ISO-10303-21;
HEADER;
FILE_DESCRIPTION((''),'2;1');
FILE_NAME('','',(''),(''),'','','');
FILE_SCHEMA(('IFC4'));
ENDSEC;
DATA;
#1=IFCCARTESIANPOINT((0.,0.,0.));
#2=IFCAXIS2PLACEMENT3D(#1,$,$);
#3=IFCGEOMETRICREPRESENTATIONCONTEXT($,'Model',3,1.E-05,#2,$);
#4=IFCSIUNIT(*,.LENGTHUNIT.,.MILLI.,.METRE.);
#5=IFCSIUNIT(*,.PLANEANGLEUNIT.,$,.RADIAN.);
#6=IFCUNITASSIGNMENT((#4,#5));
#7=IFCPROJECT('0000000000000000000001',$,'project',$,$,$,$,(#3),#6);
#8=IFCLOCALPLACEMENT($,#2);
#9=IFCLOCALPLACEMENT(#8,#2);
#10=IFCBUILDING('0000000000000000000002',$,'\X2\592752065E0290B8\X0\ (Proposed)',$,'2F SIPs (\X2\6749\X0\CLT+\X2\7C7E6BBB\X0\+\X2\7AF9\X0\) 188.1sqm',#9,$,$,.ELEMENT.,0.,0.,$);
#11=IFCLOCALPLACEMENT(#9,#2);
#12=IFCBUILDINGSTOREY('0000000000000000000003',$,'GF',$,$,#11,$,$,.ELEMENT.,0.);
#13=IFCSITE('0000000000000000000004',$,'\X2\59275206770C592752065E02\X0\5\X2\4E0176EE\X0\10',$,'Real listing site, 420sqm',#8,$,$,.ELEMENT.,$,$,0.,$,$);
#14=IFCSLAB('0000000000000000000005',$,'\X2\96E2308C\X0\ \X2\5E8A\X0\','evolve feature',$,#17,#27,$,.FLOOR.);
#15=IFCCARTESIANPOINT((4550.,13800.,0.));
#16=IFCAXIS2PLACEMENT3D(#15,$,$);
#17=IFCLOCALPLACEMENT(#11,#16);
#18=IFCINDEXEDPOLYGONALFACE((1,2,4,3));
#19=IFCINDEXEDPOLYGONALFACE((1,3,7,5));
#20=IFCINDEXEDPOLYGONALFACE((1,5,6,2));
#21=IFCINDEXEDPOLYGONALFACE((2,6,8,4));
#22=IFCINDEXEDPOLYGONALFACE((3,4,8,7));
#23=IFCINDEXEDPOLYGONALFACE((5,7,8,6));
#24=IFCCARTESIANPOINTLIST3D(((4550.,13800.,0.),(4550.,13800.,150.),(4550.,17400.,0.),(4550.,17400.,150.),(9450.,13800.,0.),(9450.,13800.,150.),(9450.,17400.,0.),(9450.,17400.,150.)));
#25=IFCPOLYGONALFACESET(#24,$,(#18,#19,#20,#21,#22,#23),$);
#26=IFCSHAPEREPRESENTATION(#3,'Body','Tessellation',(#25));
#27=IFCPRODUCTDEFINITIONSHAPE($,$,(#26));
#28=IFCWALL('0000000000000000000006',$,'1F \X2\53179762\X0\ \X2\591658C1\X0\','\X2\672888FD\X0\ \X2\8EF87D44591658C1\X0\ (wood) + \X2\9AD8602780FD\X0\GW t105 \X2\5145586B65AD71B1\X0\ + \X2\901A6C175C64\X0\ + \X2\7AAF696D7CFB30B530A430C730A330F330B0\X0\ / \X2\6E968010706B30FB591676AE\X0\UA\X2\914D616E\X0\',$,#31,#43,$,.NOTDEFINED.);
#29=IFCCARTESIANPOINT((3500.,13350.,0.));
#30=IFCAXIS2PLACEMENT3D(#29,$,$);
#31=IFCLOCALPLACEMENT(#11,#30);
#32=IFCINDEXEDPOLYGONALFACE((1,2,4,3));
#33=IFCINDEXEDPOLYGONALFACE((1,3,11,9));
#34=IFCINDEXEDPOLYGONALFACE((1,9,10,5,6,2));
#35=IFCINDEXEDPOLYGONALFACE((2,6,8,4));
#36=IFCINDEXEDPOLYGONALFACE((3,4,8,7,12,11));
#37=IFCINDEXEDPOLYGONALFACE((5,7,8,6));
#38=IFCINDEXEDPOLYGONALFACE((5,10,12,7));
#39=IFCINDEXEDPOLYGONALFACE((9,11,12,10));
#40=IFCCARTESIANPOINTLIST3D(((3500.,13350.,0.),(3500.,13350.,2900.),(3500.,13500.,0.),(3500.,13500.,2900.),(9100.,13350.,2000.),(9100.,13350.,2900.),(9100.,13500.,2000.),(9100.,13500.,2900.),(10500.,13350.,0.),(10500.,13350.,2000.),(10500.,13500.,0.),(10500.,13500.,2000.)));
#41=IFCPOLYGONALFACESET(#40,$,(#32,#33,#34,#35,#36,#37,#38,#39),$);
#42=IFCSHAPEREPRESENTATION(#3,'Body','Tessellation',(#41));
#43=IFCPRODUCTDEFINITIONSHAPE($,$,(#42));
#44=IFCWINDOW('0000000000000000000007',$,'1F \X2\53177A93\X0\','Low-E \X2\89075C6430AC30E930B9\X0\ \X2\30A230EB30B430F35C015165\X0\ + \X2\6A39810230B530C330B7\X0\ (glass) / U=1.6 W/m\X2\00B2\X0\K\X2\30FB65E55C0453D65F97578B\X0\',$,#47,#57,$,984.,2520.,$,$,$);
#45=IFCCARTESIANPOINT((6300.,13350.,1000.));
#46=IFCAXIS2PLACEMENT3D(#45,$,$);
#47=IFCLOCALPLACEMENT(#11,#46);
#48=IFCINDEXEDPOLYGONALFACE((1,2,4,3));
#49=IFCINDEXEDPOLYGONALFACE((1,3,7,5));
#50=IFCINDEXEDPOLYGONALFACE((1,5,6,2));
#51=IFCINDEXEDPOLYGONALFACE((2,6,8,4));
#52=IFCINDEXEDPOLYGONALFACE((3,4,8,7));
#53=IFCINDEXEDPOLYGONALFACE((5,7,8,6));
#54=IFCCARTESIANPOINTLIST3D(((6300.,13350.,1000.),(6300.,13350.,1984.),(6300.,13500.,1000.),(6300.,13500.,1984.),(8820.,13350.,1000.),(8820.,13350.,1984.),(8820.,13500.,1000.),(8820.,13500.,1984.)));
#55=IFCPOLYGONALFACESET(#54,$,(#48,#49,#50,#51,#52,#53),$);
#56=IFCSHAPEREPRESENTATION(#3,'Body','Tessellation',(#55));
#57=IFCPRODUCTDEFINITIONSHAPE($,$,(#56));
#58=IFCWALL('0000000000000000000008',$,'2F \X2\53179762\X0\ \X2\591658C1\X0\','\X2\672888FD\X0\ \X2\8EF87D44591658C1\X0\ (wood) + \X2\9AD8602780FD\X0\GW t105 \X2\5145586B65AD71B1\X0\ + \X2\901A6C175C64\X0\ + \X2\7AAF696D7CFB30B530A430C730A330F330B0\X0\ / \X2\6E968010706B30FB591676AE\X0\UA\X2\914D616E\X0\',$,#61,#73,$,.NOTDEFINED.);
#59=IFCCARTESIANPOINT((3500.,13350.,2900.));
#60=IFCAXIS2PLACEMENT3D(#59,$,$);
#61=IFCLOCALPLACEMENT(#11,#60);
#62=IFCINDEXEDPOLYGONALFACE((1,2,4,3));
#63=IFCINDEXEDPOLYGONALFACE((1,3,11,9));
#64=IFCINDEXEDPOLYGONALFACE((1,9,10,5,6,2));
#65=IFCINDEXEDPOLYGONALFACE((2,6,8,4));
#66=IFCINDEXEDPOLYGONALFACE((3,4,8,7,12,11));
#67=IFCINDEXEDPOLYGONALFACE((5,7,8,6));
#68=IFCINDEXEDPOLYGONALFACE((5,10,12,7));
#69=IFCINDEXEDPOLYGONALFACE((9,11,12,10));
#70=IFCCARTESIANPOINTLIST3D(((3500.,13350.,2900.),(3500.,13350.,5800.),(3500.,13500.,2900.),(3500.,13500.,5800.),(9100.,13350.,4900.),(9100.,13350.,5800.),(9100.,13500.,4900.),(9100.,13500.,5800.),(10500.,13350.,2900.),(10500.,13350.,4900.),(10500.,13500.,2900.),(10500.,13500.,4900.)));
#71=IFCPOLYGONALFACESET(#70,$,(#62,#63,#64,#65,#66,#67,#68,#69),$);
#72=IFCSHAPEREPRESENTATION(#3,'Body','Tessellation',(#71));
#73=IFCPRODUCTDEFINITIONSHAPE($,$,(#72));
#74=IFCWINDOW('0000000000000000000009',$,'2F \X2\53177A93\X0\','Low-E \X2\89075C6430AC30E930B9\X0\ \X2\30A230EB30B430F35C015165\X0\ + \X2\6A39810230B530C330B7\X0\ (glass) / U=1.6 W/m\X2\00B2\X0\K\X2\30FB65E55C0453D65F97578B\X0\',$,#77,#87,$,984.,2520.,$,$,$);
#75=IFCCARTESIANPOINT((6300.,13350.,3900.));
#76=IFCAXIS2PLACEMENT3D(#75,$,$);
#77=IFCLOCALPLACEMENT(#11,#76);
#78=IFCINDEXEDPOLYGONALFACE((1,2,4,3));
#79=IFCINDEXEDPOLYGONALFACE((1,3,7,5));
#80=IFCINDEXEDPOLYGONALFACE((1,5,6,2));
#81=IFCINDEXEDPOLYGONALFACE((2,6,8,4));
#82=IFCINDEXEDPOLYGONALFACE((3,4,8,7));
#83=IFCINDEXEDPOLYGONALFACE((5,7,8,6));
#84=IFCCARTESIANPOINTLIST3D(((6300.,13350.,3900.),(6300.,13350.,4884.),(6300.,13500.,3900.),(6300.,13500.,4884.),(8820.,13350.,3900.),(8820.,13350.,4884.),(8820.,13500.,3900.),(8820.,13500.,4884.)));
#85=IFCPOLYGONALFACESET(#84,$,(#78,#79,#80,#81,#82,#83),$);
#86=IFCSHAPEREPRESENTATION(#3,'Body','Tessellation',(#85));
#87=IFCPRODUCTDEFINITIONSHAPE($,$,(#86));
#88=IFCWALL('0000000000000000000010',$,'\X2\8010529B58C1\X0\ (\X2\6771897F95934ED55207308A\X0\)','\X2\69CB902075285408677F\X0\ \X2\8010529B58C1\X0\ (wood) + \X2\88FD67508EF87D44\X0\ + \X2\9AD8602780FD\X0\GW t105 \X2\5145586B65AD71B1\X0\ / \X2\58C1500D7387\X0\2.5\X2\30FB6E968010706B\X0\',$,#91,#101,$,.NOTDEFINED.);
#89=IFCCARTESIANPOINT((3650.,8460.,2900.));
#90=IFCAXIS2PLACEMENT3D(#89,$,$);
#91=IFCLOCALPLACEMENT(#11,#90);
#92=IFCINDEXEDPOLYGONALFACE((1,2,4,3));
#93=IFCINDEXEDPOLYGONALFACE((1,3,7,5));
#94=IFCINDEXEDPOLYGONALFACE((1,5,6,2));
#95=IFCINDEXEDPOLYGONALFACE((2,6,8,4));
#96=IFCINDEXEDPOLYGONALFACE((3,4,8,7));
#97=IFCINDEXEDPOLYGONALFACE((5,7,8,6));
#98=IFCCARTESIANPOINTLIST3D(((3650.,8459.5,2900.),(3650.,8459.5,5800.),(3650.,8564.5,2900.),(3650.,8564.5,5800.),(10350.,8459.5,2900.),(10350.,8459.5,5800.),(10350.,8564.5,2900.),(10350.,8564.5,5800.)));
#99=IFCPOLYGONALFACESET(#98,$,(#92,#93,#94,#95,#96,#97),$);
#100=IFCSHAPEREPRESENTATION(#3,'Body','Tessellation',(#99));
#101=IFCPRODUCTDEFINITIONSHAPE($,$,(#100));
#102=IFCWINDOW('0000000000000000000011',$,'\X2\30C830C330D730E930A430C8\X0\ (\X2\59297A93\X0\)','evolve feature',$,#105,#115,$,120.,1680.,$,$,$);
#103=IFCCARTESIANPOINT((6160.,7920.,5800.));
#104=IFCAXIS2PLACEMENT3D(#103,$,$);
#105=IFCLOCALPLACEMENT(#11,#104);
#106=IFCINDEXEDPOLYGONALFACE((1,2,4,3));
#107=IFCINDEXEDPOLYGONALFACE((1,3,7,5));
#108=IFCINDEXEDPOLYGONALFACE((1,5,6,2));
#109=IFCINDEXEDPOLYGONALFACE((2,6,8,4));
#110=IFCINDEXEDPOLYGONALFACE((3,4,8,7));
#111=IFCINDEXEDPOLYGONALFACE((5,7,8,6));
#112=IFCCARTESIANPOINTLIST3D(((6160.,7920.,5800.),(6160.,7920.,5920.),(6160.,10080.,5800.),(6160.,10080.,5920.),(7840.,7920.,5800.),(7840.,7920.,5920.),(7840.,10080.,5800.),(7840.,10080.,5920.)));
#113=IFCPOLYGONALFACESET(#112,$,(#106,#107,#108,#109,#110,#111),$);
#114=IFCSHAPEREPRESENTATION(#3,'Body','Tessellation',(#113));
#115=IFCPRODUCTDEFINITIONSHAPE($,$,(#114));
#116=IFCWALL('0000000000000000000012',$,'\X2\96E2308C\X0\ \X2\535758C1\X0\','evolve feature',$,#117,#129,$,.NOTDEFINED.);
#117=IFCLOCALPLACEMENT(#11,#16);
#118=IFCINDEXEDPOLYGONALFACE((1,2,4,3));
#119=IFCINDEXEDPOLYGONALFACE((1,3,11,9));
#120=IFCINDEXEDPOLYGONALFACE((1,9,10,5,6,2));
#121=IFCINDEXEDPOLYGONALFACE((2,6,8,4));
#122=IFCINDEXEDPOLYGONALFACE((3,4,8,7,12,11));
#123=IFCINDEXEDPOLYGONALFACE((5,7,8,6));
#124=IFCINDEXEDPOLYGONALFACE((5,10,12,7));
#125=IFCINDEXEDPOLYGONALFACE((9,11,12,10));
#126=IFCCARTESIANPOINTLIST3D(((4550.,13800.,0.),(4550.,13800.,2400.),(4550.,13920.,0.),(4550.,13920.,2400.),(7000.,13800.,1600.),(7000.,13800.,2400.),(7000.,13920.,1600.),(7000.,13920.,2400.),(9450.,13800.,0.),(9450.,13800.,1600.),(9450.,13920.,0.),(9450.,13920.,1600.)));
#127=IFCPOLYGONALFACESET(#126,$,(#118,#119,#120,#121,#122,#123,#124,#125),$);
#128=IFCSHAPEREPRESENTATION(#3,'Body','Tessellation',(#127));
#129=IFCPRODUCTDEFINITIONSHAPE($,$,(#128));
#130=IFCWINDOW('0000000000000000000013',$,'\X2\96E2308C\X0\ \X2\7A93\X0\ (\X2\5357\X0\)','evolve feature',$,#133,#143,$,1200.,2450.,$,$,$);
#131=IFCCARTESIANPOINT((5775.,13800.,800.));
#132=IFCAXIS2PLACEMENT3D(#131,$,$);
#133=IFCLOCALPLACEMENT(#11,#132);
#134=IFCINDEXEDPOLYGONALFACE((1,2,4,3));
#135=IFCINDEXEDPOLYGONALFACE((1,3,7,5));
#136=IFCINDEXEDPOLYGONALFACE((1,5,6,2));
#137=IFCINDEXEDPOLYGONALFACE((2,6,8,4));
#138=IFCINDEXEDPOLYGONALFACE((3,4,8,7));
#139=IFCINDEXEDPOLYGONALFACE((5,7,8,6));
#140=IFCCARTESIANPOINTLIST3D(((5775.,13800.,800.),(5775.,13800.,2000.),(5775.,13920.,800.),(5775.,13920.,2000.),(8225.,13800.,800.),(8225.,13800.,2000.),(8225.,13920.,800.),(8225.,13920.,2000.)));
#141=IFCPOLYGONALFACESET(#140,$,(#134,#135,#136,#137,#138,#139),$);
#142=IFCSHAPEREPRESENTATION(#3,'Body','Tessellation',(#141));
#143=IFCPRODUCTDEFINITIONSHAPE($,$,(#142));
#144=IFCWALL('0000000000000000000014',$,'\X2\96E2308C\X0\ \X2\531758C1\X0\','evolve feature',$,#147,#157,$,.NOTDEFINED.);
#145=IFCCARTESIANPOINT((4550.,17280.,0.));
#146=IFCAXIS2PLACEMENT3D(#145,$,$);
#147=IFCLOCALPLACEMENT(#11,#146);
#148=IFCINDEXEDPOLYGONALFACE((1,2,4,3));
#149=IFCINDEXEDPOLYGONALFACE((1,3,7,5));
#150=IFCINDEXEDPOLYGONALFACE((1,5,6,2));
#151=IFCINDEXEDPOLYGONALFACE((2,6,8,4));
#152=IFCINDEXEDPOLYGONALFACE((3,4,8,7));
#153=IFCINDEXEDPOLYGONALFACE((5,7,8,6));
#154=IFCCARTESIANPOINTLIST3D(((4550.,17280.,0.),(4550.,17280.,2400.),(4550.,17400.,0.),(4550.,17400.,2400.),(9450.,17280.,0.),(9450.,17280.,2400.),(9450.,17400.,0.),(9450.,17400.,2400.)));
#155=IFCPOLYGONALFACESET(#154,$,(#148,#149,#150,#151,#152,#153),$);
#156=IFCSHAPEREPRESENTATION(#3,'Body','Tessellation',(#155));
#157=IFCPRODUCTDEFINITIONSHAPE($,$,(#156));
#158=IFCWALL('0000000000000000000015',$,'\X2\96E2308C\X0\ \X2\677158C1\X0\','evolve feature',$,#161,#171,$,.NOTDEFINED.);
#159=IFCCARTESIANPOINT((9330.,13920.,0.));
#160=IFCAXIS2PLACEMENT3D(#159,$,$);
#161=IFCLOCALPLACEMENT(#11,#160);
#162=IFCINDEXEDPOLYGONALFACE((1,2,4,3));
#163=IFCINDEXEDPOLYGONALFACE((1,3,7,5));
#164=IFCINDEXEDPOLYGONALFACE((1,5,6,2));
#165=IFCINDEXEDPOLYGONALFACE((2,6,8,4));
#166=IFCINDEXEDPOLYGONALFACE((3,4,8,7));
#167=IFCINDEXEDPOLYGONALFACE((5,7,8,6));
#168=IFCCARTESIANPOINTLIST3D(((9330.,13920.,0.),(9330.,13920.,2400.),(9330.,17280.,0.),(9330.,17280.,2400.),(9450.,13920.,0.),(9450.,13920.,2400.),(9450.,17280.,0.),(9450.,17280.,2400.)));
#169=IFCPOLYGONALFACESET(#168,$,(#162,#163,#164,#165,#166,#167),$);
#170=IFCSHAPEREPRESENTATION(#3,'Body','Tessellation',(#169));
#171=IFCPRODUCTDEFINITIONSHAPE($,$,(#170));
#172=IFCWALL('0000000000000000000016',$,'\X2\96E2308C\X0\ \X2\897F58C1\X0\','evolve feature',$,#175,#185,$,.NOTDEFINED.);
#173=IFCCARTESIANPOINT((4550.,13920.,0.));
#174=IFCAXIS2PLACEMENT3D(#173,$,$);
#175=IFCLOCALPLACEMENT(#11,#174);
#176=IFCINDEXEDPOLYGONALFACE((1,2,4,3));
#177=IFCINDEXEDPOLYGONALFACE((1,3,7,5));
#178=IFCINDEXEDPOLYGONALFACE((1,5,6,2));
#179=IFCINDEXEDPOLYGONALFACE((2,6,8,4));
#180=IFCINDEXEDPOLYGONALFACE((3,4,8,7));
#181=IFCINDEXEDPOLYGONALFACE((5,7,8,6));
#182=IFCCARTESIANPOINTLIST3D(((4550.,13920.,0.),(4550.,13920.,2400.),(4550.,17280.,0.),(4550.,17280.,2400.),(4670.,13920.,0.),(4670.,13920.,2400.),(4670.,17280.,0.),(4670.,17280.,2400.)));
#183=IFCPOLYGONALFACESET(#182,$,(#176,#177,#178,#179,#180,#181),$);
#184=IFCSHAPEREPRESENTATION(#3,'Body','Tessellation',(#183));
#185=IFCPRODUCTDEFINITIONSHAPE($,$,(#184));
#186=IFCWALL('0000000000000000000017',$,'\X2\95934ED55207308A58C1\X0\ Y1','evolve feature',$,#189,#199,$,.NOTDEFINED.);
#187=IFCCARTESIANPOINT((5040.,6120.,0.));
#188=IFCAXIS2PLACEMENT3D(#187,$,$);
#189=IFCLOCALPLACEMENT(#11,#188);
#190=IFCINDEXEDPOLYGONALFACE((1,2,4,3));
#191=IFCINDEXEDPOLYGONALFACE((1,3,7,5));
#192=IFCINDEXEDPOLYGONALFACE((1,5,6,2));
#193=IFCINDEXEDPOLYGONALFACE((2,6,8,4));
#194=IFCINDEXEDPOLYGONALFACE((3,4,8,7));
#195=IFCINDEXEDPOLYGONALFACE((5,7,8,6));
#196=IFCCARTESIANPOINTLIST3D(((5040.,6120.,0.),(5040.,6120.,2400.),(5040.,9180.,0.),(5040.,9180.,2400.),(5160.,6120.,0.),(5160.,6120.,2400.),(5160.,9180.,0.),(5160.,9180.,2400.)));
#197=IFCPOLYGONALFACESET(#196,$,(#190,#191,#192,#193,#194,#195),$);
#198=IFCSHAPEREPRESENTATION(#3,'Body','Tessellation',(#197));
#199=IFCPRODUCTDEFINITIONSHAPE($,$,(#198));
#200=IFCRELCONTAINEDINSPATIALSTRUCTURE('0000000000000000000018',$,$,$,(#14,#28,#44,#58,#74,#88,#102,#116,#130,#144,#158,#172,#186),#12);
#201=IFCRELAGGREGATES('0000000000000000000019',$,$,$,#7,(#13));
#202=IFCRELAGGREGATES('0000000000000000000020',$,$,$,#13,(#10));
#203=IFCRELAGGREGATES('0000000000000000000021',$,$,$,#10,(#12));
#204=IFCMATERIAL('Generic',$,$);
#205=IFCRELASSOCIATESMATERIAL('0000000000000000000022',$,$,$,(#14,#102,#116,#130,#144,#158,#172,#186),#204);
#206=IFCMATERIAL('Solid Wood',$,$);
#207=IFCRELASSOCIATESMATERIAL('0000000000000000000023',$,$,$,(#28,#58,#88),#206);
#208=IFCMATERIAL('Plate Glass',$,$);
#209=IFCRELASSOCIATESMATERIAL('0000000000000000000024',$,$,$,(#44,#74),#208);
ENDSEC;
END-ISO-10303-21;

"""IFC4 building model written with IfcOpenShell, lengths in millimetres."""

from ifc_helpers import new_model, si_unit, frame, frame_2d, origin, place, context, project, spatial, rectangle, extrude, material, element, fill, save


model = new_model("IFC4")

# Units and contexts
model_context = context("Model", 3, precision=1e-05, world=origin())
ifc_project = project(units=[si_unit("LENGTHUNIT", "METRE", prefix="MILLI"), si_unit("PLANEANGLEUNIT", "RADIAN")], contexts=[model_context])

# Site, building, storey
site_placement = place(None, origin())
site = spatial("IfcSite", under=ifc_project, at=site_placement, Name="大分県大分市5丁目10", ObjectType="Real listing site, 420sqm", CompositionType="ELEMENT", RefElevation=0.0)
building_placement = place(site_placement, origin())
building = spatial("IfcBuilding", under=site, at=building_placement, Name="大分市邸 (Proposed)", ObjectType="2F SIPs (杉CLT+籾殻+竹) 188.1sqm", CompositionType="ELEMENT", ElevationOfRefHeight=0.0, ElevationOfTerrain=0.0)
storey_placement = place(building_placement, origin())
storey = spatial("IfcBuildingStorey", under=building, at=storey_placement, Name="GF", CompositionType="ELEMENT", Elevation=0.0)

# Slab
ifc_material_1 = material(Name="Generic")
slab_placement = place(storey_placement, frame((4550.0, 13800.0, 0.0)))
element("IfcSlab", 1, at=slab_placement, inside=storey, material=ifc_material_1, Name="離れ 床", Description="evolve feature", PredefinedType="FLOOR", context=model_context, shape_type="SweptSolid", body=[
    extrude(rectangle(XDim=4900.0, YDim=3600.0, at=frame_2d((2450.0, 1800.0))), frame((4550.0, 13800.0, 0.0)), (0.0, 0.0, 1.0), 150.0),
])

# Wall, opening, window
ifc_material_2 = material(Name="Solid Wood")
wall_1_placement = place(storey_placement, frame((3500.0, 13350.0, 0.0)))
wall_1 = element("IfcWall", 2, at=wall_1_placement, inside=storey, material=ifc_material_2, Name="1F 北面 外壁", Description="木製 軸組外壁 (wood) + 高性能GW t105 充填断熱 + 通気層 + 窯業系サイディング / 準耐火・外皮UA配慮", PredefinedType="NOTDEFINED", context=model_context, shape_type="SweptSolid", body=[
    extrude(rectangle(XDim=7000.0, YDim=150.0, at=frame_2d((3500.0, 75.0))), frame((3500.0, 13350.0, 0.0)), (0.0, 0.0, 1.0), 2900.0),
])
opening_1_placement = place(storey_placement, frame((6300.0, 13350.0, 1000.0)))
opening_1 = element("IfcOpeningElement", 3, at=opening_1_placement, cuts=wall_1, PredefinedType="NOTDEFINED", context=model_context, shape_type="SweptSolid", body=[
    extrude(rectangle(XDim=2520.0, YDim=150.0, at=frame_2d((1260.0, 75.0))), frame((6300.0, 13350.0, 1000.0)), (0.0, 0.0, 1.0), 984.0),
])
ifc_material_3 = material(Name="Plate Glass")
window_1_placement = place(storey_placement, frame((6300.0, 13350.0, 1000.0)))
window_1 = element("IfcWindow", 4, at=window_1_placement, inside=storey, material=ifc_material_3, Name="1F 北窓", Description="Low-E 複層ガラス アルゴン封入 + 樹脂サッシ (glass) / U=1.6 W/m²K・日射取得型", OverallHeight=984.0, OverallWidth=2520.0, context=model_context, shape_type="SweptSolid", body=[
    extrude(rectangle(XDim=2520.0, YDim=150.0, at=frame_2d((1260.0, 75.0))), frame((6300.0, 13350.0, 1000.0)), (0.0, 0.0, 1.0), 984.0),
])
fill(opening_1, window_1)

# Wall, opening, window
wall_2_placement = place(storey_placement, frame((3500.0, 13350.0, 2900.0)))
wall_2 = element("IfcWall", 5, at=wall_2_placement, inside=storey, material=ifc_material_2, Name="2F 北面 外壁", Description="木製 軸組外壁 (wood) + 高性能GW t105 充填断熱 + 通気層 + 窯業系サイディング / 準耐火・外皮UA配慮", PredefinedType="NOTDEFINED", context=model_context, shape_type="SweptSolid", body=[
    extrude(rectangle(XDim=7000.0, YDim=150.0, at=frame_2d((3500.0, 75.0))), frame((3500.0, 13350.0, 2900.0)), (0.0, 0.0, 1.0), 2900.0),
])
opening_2_placement = place(storey_placement, frame((6300.0, 13350.0, 3900.0)))
opening_2 = element("IfcOpeningElement", 6, at=opening_2_placement, cuts=wall_2, PredefinedType="NOTDEFINED", context=model_context, shape_type="SweptSolid", body=[
    extrude(rectangle(XDim=2520.0, YDim=150.0, at=frame_2d((1260.0, 75.0))), frame((6300.0, 13350.0, 3900.0)), (0.0, 0.0, 1.0), 984.0),
])
window_2_placement = place(storey_placement, frame((6300.0, 13350.0, 3900.0)))
window_2 = element("IfcWindow", 7, at=window_2_placement, inside=storey, material=ifc_material_3, Name="2F 北窓", Description="Low-E 複層ガラス アルゴン封入 + 樹脂サッシ (glass) / U=1.6 W/m²K・日射取得型", OverallHeight=984.0, OverallWidth=2520.0, context=model_context, shape_type="SweptSolid", body=[
    extrude(rectangle(XDim=2520.0, YDim=150.0, at=frame_2d((1260.0, 75.0))), frame((6300.0, 13350.0, 3900.0)), (0.0, 0.0, 1.0), 984.0),
])
fill(opening_2, window_2)

# Wall
wall_3_placement = place(storey_placement, frame((3650.0, 8460.0, 2900.0)))
element("IfcWall", 8, at=wall_3_placement, inside=storey, material=ifc_material_2, Name="耐力壁 (東西間仕切り)", Description="構造用合板 耐力壁 (wood) + 製材軸組 + 高性能GW t105 充填断熱 / 壁倍率2.5・準耐火", PredefinedType="NOTDEFINED", context=model_context, shape_type="SweptSolid", body=[
    extrude(rectangle(XDim=6700.0, YDim=105.0, at=frame_2d((3350.0, 52.0))), frame((3650.0, 8460.0, 2900.0)), (0.0, 0.0, 1.0), 2900.0),
])

# Window
window_3_placement = place(storey_placement, frame((6160.0, 7920.0, 5800.0)))
element("IfcWindow", 9, at=window_3_placement, inside=storey, material=ifc_material_1, Name="トップライト (天窓)", Description="evolve feature", OverallHeight=120.0, OverallWidth=1680.0, context=model_context, shape_type="SweptSolid", body=[
    extrude(rectangle(XDim=1680.0, YDim=2160.0, at=frame_2d((840.0, 1080.0))), frame((6160.0, 7920.0, 5800.0)), (0.0, 0.0, 1.0), 120.0),
])

# Wall, opening, window
wall_4_placement = place(storey_placement, frame((4550.0, 13800.0, 0.0)))
wall_4 = element("IfcWall", 10, at=wall_4_placement, inside=storey, material=ifc_material_1, Name="離れ 南壁", Description="evolve feature", PredefinedType="NOTDEFINED", context=model_context, shape_type="SweptSolid", body=[
    extrude(rectangle(XDim=4900.0, YDim=120.0, at=frame_2d((2450.0, 60.0))), frame((4550.0, 13800.0, 0.0)), (0.0, 0.0, 1.0), 2400.0),
])
opening_3_placement = place(storey_placement, frame((5775.0, 13800.0, 800.0)))
opening_3 = element("IfcOpeningElement", 11, at=opening_3_placement, cuts=wall_4, PredefinedType="NOTDEFINED", context=model_context, shape_type="SweptSolid", body=[
    extrude(rectangle(XDim=2450.0, YDim=120.0, at=frame_2d((1225.0, 60.0))), frame((5775.0, 13800.0, 800.0)), (0.0, 0.0, 1.0), 1200.0),
])
window_4_placement = place(storey_placement, frame((5775.0, 13800.0, 800.0)))
window_4 = element("IfcWindow", 12, at=window_4_placement, inside=storey, material=ifc_material_1, Name="離れ 窓 (南)", Description="evolve feature", OverallHeight=1200.0, OverallWidth=2450.0, context=model_context, shape_type="SweptSolid", body=[
    extrude(rectangle(XDim=2450.0, YDim=120.0, at=frame_2d((1225.0, 60.0))), frame((5775.0, 13800.0, 800.0)), (0.0, 0.0, 1.0), 1200.0),
])
fill(opening_3, window_4)

# Walls
wall_5_placement = place(storey_placement, frame((4550.0, 17280.0, 0.0)))
element("IfcWall", 13, at=wall_5_placement, inside=storey, material=ifc_material_1, Name="離れ 北壁", Description="evolve feature", PredefinedType="NOTDEFINED", context=model_context, shape_type="SweptSolid", body=[
    extrude(rectangle(XDim=4900.0, YDim=120.0, at=frame_2d((2450.0, 60.0))), frame((4550.0, 17280.0, 0.0)), (0.0, 0.0, 1.0), 2400.0),
])
wall_6_placement = place(storey_placement, frame((9330.0, 13920.0, 0.0)))
element("IfcWall", 14, at=wall_6_placement, inside=storey, material=ifc_material_1, Name="離れ 東壁", Description="evolve feature", PredefinedType="NOTDEFINED", context=model_context, shape_type="SweptSolid", body=[
    extrude(rectangle(XDim=120.0, YDim=3360.0, at=frame_2d((60.0, 1680.0))), frame((9330.0, 13920.0, 0.0)), (0.0, 0.0, 1.0), 2400.0),
])
wall_7_placement = place(storey_placement, frame((4550.0, 13920.0, 0.0)))
element("IfcWall", 15, at=wall_7_placement, inside=storey, material=ifc_material_1, Name="離れ 西壁", Description="evolve feature", PredefinedType="NOTDEFINED", context=model_context, shape_type="SweptSolid", body=[
    extrude(rectangle(XDim=120.0, YDim=3360.0, at=frame_2d((60.0, 1680.0))), frame((4550.0, 13920.0, 0.0)), (0.0, 0.0, 1.0), 2400.0),
])
wall_8_placement = place(storey_placement, frame((5040.0, 6120.0, 0.0)))
element("IfcWall", 16, at=wall_8_placement, inside=storey, material=ifc_material_1, Name="間仕切り壁 Y1", Description="evolve feature", PredefinedType="NOTDEFINED", context=model_context, shape_type="SweptSolid", body=[
    extrude(rectangle(XDim=120.0, YDim=3060.0, at=frame_2d((60.0, 1530.0))), frame((5040.0, 6120.0, 0.0)), (0.0, 0.0, 1.0), 2400.0),
])

save(model, "model.ifc")
